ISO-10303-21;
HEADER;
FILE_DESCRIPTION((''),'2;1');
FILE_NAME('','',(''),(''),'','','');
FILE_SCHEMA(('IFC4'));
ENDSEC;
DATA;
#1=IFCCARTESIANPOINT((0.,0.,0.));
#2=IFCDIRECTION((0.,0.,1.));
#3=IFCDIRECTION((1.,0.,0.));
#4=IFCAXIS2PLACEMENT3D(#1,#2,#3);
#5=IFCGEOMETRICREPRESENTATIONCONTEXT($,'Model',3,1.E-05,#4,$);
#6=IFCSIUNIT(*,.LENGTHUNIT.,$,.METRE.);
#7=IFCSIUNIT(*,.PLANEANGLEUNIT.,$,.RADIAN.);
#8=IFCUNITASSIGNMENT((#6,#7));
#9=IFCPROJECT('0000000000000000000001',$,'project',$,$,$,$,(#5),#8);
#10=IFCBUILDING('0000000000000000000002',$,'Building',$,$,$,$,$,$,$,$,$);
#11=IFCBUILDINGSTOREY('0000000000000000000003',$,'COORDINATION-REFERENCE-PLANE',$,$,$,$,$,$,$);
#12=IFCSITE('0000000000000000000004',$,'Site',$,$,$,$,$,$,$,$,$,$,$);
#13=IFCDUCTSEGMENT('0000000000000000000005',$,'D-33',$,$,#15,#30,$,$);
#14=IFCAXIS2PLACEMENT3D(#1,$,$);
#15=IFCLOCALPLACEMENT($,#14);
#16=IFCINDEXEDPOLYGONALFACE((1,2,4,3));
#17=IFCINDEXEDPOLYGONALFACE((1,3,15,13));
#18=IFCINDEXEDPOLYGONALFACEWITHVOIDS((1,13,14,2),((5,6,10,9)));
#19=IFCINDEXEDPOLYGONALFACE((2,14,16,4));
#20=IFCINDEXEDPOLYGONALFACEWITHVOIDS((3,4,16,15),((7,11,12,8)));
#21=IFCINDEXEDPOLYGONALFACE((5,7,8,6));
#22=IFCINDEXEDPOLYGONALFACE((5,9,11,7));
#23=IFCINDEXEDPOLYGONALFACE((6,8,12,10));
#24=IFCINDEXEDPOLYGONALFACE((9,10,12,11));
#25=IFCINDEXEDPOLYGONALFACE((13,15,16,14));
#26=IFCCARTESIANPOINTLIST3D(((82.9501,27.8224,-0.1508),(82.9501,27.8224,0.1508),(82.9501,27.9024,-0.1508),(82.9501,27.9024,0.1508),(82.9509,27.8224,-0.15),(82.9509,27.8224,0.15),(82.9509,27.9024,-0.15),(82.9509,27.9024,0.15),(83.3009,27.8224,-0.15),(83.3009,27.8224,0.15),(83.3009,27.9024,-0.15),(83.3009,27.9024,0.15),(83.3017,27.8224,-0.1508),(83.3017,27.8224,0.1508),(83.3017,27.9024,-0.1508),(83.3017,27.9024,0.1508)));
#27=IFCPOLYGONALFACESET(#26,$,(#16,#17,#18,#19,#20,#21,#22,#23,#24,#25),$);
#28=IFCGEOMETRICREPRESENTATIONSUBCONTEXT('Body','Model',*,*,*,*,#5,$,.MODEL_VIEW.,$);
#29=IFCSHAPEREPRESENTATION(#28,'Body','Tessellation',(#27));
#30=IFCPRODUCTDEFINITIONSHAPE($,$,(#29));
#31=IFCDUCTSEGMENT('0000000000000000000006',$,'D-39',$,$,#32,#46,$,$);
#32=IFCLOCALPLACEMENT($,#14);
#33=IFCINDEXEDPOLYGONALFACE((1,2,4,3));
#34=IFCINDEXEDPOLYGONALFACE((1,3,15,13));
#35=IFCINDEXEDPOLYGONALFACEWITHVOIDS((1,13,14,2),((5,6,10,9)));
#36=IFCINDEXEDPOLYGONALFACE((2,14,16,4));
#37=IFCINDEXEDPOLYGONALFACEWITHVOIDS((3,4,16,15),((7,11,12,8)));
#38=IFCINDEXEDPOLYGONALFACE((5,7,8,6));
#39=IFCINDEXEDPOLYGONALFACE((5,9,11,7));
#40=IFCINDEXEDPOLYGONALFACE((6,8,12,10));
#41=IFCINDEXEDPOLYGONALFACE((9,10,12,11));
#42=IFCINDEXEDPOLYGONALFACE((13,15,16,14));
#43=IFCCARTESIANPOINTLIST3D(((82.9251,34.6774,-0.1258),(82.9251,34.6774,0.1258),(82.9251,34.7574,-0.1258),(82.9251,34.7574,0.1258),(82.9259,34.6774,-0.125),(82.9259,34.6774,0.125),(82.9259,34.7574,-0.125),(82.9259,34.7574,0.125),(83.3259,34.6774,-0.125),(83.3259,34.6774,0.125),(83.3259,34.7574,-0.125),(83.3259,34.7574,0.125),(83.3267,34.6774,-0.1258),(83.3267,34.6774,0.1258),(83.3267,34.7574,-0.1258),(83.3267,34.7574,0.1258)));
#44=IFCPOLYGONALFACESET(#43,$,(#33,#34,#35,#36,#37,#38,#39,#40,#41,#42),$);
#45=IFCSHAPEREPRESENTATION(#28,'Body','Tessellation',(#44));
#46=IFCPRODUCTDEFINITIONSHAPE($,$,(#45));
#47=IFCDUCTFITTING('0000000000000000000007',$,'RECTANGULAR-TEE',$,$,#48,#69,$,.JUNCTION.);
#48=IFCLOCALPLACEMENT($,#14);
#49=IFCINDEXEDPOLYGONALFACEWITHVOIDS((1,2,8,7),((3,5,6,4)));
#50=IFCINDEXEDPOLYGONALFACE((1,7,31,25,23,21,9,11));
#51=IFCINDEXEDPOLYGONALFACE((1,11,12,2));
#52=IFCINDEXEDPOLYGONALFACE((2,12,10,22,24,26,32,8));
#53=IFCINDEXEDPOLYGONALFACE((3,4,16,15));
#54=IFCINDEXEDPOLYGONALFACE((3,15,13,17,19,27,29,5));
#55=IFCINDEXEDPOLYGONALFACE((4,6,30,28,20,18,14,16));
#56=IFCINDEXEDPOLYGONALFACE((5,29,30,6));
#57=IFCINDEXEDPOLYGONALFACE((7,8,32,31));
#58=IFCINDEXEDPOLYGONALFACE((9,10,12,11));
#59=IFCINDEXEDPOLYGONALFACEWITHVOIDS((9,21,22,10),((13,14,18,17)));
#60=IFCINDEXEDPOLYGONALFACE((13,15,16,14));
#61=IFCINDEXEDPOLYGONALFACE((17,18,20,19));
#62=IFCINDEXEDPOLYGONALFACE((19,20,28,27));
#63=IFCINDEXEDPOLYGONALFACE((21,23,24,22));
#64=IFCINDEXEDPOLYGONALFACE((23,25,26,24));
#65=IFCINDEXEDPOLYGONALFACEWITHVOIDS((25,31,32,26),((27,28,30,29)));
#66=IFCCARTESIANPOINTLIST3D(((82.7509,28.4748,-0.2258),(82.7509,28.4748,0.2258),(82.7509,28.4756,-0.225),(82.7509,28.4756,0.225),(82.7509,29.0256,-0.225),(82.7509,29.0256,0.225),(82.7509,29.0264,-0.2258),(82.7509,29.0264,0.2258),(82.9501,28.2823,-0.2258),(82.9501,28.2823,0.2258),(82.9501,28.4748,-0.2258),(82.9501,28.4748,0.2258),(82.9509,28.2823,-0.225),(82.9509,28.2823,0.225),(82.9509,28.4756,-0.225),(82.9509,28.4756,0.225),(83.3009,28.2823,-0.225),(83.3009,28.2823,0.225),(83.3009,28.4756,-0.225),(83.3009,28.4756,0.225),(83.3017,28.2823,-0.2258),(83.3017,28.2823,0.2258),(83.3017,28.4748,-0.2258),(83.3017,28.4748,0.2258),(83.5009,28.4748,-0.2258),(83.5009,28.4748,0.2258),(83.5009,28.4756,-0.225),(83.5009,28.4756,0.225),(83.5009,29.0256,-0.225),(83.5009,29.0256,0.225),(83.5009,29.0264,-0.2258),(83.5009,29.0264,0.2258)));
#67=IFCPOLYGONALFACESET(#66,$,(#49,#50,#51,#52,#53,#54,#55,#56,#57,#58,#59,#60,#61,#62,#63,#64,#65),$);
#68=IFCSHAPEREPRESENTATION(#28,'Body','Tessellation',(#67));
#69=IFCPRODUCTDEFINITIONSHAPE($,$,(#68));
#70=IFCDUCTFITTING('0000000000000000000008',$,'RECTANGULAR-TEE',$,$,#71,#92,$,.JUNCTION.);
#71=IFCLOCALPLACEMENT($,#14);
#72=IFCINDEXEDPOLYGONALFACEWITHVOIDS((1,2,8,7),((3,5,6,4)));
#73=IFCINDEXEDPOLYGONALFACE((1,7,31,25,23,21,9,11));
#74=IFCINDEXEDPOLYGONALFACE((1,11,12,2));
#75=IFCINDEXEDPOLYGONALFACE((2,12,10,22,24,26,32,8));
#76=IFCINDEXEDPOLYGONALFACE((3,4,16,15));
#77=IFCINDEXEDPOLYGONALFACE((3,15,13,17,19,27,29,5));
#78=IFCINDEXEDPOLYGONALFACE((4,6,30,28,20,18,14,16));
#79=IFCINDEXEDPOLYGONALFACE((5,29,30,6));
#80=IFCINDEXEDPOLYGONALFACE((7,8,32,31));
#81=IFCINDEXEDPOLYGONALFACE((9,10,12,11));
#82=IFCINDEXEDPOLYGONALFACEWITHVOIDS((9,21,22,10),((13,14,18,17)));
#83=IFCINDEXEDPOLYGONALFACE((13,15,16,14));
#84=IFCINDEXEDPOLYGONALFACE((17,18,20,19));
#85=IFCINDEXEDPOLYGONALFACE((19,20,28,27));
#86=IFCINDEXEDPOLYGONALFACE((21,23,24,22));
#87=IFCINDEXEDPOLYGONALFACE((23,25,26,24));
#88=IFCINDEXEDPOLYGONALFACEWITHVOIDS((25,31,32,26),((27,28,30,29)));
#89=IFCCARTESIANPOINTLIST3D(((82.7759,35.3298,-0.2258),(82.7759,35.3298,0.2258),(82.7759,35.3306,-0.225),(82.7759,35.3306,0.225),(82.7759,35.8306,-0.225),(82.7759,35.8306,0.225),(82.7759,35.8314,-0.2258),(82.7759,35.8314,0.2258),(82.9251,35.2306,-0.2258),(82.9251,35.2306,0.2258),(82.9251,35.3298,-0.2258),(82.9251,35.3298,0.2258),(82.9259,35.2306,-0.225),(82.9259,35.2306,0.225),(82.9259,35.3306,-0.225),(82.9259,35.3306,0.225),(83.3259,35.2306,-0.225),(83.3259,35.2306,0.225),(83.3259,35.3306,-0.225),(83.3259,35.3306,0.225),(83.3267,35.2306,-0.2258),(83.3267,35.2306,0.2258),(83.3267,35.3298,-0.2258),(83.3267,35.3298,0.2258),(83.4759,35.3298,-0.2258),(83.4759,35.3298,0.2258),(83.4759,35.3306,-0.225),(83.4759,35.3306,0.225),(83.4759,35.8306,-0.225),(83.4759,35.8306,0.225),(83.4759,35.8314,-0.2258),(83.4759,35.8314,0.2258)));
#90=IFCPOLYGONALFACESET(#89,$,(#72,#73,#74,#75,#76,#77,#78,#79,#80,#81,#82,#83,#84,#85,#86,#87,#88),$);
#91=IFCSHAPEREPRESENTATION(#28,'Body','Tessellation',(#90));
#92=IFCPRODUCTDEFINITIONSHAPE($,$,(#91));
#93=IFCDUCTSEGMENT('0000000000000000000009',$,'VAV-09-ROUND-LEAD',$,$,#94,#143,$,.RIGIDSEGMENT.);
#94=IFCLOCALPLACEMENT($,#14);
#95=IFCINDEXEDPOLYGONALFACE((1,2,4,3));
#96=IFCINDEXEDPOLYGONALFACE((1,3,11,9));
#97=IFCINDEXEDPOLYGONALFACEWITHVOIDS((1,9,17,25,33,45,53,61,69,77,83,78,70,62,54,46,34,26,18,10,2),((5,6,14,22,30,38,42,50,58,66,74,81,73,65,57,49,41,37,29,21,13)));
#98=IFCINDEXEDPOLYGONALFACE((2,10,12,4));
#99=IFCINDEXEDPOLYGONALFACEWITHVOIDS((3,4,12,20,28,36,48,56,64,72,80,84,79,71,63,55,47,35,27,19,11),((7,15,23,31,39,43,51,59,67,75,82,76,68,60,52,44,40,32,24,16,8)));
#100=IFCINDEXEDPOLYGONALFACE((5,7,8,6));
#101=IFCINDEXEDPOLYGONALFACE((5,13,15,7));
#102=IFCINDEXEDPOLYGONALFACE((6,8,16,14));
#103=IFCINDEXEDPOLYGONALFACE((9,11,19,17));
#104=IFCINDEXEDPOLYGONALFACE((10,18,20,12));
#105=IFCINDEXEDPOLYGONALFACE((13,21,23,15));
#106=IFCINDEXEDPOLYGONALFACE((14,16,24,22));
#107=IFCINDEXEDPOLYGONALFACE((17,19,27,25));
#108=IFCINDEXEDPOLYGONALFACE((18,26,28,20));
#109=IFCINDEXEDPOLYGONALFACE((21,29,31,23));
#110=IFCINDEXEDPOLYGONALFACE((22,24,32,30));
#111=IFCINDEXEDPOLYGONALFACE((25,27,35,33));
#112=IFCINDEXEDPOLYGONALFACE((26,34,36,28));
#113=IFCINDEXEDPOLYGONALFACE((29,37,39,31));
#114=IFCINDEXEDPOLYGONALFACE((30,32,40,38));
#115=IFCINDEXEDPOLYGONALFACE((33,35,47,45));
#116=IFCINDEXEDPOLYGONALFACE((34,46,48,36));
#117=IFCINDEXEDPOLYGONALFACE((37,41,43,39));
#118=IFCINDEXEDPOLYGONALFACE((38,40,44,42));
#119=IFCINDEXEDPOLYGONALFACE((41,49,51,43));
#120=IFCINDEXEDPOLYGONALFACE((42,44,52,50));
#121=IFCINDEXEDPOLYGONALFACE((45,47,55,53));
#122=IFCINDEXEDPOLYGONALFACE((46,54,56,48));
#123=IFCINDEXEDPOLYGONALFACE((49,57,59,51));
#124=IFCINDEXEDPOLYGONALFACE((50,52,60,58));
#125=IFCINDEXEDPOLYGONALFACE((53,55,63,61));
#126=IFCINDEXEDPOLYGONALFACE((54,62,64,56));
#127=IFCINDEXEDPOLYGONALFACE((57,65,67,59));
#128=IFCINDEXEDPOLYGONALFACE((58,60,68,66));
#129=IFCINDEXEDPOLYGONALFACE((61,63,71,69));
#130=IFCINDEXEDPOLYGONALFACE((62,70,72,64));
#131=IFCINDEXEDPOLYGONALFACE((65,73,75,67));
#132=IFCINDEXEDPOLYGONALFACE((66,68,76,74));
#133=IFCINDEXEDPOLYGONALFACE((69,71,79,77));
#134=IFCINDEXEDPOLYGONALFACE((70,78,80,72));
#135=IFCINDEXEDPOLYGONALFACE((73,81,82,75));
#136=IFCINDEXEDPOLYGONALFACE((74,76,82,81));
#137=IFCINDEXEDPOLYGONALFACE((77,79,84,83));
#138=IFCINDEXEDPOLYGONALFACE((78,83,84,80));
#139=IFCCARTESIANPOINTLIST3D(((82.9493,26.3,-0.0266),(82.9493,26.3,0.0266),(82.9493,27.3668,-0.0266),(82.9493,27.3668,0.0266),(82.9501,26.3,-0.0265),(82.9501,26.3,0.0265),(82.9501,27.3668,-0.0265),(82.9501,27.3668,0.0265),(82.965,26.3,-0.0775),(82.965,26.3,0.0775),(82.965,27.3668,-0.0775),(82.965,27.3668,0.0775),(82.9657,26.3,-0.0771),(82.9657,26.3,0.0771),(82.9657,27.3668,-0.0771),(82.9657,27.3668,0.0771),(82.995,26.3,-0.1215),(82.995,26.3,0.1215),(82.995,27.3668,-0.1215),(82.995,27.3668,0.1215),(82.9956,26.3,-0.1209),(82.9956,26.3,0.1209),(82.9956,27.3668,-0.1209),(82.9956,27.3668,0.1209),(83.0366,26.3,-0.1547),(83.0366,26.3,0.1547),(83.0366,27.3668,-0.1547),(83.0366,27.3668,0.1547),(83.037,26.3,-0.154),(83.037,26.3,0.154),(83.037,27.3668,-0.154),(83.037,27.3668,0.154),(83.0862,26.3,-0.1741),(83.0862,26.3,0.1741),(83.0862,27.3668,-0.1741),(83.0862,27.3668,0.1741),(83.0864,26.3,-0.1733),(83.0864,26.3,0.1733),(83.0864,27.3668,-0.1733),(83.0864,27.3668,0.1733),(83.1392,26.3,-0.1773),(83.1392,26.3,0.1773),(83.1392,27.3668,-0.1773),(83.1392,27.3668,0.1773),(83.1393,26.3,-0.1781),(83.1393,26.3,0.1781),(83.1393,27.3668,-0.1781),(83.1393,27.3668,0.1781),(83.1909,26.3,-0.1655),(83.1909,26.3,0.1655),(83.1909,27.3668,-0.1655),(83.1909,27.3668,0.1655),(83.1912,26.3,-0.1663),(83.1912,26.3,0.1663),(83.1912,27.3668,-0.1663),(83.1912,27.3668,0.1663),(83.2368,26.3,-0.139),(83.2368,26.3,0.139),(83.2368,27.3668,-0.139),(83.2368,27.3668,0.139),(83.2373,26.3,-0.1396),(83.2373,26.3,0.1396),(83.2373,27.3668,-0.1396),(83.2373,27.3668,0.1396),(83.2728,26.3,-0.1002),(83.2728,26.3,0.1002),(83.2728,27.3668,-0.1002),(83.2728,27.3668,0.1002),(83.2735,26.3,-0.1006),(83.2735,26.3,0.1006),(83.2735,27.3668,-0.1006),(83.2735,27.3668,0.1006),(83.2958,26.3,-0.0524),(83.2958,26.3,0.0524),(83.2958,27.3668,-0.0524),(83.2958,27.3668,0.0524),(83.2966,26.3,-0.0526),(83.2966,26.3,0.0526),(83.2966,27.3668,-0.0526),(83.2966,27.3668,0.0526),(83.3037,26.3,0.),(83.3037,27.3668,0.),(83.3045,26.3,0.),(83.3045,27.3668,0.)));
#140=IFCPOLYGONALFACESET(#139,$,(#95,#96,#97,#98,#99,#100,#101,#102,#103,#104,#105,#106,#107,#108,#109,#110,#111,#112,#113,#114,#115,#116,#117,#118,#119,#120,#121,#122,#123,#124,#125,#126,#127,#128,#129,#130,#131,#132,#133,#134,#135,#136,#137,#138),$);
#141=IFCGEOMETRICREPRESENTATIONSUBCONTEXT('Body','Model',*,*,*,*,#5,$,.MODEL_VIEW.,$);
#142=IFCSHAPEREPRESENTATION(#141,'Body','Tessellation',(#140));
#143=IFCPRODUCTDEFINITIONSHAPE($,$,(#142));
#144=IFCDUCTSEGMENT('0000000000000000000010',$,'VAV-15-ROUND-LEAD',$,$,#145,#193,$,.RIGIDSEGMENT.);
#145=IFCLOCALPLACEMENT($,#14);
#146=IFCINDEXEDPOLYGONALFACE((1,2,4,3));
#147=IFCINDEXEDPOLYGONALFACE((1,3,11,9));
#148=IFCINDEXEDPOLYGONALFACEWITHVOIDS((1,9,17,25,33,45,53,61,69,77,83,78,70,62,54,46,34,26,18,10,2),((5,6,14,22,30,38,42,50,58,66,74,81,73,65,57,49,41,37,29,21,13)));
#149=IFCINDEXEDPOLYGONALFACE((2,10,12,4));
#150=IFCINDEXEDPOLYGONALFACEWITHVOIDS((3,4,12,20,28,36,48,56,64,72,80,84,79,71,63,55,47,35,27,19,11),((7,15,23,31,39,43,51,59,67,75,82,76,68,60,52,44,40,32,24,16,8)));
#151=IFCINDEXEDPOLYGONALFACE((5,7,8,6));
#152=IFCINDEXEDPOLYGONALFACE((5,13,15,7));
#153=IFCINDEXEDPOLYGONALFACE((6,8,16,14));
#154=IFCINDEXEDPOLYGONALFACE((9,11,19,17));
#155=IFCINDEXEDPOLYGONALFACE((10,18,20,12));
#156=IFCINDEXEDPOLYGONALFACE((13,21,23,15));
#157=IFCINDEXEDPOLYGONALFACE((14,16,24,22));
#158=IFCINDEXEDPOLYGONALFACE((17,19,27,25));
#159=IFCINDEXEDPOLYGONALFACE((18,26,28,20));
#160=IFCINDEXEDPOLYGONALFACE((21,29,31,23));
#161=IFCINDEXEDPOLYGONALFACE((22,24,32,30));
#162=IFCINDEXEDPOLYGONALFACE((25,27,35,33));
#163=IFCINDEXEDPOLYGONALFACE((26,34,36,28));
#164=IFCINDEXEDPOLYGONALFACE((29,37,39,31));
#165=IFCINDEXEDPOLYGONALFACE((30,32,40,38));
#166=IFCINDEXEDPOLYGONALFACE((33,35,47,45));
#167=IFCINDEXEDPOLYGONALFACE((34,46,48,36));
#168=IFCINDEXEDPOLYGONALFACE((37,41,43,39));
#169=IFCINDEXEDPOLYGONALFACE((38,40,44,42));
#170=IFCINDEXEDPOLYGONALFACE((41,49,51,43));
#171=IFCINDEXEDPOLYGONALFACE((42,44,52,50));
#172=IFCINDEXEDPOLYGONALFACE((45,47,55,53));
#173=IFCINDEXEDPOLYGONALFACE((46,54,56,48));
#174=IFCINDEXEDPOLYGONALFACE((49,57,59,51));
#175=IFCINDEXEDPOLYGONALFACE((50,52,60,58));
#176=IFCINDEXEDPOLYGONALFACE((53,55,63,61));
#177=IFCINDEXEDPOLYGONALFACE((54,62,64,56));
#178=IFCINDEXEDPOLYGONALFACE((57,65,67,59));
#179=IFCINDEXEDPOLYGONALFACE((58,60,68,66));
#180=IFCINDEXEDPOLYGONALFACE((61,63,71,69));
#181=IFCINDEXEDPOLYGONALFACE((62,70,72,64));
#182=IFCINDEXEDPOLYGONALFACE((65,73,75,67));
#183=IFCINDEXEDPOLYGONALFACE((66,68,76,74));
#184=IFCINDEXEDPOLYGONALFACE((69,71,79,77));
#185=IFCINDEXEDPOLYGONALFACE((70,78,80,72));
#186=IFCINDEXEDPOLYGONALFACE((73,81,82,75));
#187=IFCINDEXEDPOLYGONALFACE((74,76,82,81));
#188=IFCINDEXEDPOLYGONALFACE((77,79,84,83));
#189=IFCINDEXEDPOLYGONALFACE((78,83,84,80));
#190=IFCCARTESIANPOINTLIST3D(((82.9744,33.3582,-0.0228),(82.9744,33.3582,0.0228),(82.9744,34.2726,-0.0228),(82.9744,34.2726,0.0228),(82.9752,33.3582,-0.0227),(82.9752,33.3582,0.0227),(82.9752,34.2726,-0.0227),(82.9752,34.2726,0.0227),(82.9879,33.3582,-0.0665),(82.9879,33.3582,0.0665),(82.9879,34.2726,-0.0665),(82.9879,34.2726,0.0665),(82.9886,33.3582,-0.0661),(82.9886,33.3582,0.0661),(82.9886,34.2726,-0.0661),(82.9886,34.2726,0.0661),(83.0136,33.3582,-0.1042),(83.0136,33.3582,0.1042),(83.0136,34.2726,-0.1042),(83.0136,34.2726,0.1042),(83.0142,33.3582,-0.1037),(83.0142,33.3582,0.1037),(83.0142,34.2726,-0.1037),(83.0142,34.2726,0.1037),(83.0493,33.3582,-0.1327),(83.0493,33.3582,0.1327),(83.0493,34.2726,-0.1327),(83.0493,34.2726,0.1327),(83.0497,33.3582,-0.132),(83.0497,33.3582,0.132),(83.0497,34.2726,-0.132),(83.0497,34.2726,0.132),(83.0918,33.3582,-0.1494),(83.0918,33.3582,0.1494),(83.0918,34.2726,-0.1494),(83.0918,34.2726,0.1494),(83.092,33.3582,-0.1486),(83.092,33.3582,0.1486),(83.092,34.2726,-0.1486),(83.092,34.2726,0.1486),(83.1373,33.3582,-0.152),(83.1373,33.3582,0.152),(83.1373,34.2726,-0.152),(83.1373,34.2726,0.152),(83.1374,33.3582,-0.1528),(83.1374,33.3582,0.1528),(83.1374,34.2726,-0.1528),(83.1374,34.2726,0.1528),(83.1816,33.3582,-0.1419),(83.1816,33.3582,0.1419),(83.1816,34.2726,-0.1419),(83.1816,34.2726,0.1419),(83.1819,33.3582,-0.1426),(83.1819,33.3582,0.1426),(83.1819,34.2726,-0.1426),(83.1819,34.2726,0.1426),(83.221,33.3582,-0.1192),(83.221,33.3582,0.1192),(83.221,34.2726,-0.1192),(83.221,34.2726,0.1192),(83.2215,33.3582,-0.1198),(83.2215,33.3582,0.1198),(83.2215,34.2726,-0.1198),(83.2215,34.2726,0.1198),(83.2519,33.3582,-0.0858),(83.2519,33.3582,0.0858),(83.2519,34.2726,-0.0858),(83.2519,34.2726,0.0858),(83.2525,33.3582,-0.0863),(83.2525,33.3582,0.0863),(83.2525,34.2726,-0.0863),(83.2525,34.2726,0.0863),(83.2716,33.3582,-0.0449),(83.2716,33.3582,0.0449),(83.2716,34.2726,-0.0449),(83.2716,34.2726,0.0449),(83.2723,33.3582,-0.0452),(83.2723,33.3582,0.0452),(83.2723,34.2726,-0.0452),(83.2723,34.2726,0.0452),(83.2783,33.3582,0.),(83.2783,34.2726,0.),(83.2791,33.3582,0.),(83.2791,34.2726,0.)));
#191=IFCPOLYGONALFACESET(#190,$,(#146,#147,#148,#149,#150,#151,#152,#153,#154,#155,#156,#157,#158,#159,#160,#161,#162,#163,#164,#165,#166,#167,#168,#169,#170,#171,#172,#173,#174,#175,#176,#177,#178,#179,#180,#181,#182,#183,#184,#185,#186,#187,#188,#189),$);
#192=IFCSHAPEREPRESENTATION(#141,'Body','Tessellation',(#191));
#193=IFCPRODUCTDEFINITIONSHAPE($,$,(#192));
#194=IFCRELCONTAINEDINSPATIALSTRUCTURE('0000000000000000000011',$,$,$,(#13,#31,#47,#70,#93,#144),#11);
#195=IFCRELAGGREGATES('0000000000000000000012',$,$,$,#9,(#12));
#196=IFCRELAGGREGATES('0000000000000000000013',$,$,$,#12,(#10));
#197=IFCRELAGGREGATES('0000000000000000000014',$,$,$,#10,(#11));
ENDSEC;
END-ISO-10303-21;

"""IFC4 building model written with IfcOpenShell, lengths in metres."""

from ifc_helpers import new_model, si_unit, frame, origin, origin_with_axes, place, context, subcontext, project, spatial, rectangle, hollow_rectangle, hollow_circle, extrude, boolean, element, save


model = new_model("IFC4")

# Units and contexts
model_context = context("Model", 3, precision=1e-05, world=origin_with_axes())
body_context_1 = subcontext(model_context, "Body", "Model", "MODEL_VIEW")
body_context_2 = subcontext(model_context, "Body", "Model", "MODEL_VIEW")
ifc_project = project(units=[si_unit("LENGTHUNIT", "METRE"), si_unit("PLANEANGLEUNIT", "RADIAN")], contexts=[model_context])

# Site, building, storey
site = spatial("IfcSite", under=ifc_project, Name="Site")
building = spatial("IfcBuilding", under=site, Name="Building")
storey = spatial("IfcBuildingStorey", under=building, Name="COORDINATION-REFERENCE-PLANE")

# Duct segments
duct_segment_1_placement = place(None, frame((83.1259, 27.8224, 0.0), z_axis=(0.0, 1.0, 0.0), x_axis=(1.0, 0.0, 0.0)))
element("IfcDuctSegment", 1, at=duct_segment_1_placement, inside=storey, Name="D-33", context=body_context_1, shape_type="SweptSolid", body=[
    extrude(hollow_rectangle(XDim=0.3516, YDim=0.3016, WallThickness=0.0008), origin(), (0.0, 0.0, 1.0), 0.08),
])
duct_segment_2_placement = place(None, frame((83.1259, 34.6774, 0.0), z_axis=(0.0, 1.0, 0.0), x_axis=(1.0, 0.0, 0.0)))
element("IfcDuctSegment", 2, at=duct_segment_2_placement, inside=storey, Name="D-39", context=body_context_1, shape_type="SweptSolid", body=[
    extrude(hollow_rectangle(XDim=0.4016, YDim=0.2516, WallThickness=0.0008), origin(), (0.0, 0.0, 1.0), 0.08),
])

# Duct fittings
duct_fitting_1_placement = place(None, frame((83.1259, 28.7506, 0.0), z_axis=(-1.0, 0.0, 0.0), x_axis=(0.0, -1.0, 0.0)))
solid_1 = boolean("UNION", extrude(rectangle(XDim=0.55, YDim=0.45), frame((0.0, 0.0, -0.375), z_axis=(0.0, 0.0, 1.0), x_axis=(1.0, 0.0, 0.0)), (0.0, 0.0, 1.0), 0.75), extrude(rectangle(XDim=0.35, YDim=0.45), frame((0.0, 0.0, 0.0), z_axis=(1.0, 0.0, 0.0), x_axis=(0.0, 0.0, -1.0)), (0.0, 0.0, 1.0), 0.4683))
element("IfcDuctFitting", 3, at=duct_fitting_1_placement, inside=storey, Name="RECTANGULAR-TEE", PredefinedType="JUNCTION", context=body_context_1, shape_type="CSG", body=[
    boolean("DIFFERENCE", boolean("UNION", extrude(rectangle(XDim=0.5516, YDim=0.4516), frame((0.0, 0.0, -0.375), z_axis=(0.0, 0.0, 1.0), x_axis=(1.0, 0.0, 0.0)), (0.0, 0.0, 1.0), 0.75), extrude(rectangle(XDim=0.3516, YDim=0.4516), frame((0.0, 0.0, 0.0), z_axis=(1.0, 0.0, 0.0), x_axis=(0.0, 0.0, -1.0)), (0.0, 0.0, 1.0), 0.4683)), solid_1),
])
duct_fitting_2_placement = place(None, frame((83.1259, 35.5806, 0.0), z_axis=(-1.0, 0.0, 0.0), x_axis=(0.0, -1.0, 0.0)))
solid_2 = boolean("UNION", extrude(rectangle(XDim=0.5, YDim=0.45), frame((0.0, 0.0, -0.35), z_axis=(0.0, 0.0, 1.0), x_axis=(1.0, 0.0, 0.0)), (0.0, 0.0, 1.0), 0.7), extrude(rectangle(XDim=0.4, YDim=0.45), frame((0.0, 0.0, 0.0), z_axis=(1.0, 0.0, 0.0), x_axis=(0.0, 0.0, -1.0)), (0.0, 0.0, 1.0), 0.35))
element("IfcDuctFitting", 4, at=duct_fitting_2_placement, inside=storey, Name="RECTANGULAR-TEE", PredefinedType="JUNCTION", context=body_context_1, shape_type="CSG", body=[
    boolean("DIFFERENCE", boolean("UNION", extrude(rectangle(XDim=0.5016, YDim=0.4516), frame((0.0, 0.0, -0.35), z_axis=(0.0, 0.0, 1.0), x_axis=(1.0, 0.0, 0.0)), (0.0, 0.0, 1.0), 0.7), extrude(rectangle(XDim=0.4016, YDim=0.4516), frame((0.0, 0.0, 0.0), z_axis=(1.0, 0.0, 0.0), x_axis=(0.0, 0.0, -1.0)), (0.0, 0.0, 1.0), 0.35)), solid_2),
])

# Duct segments
duct_segment_3_placement = place(None, frame((83.1259, 27.3668, 0.0), z_axis=(0.0, -1.0, 0.0), x_axis=(1.0, 0.0, 0.0)))
element("IfcDuctSegment", 5, at=duct_segment_3_placement, inside=storey, Name="VAV-09-ROUND-LEAD", PredefinedType="RIGIDSEGMENT", context=body_context_2, shape_type="SweptSolid", body=[
    extrude(hollow_circle(Radius=0.1786, WallThickness=0.0008), origin(), (0.0, 0.0, 1.0), 1.0668),
])
duct_segment_4_placement = place(None, frame((83.1259, 34.2726, 0.0), z_axis=(0.0, -1.0, 0.0), x_axis=(1.0, 0.0, 0.0)))
element("IfcDuctSegment", 6, at=duct_segment_4_placement, inside=storey, Name="VAV-15-ROUND-LEAD", PredefinedType="RIGIDSEGMENT", context=body_context_2, shape_type="SweptSolid", body=[
    extrude(hollow_circle(Radius=0.1532, WallThickness=0.0008), origin(), (0.0, 0.0, 1.0), 0.9144),
])

save(model, "model.ifc")
